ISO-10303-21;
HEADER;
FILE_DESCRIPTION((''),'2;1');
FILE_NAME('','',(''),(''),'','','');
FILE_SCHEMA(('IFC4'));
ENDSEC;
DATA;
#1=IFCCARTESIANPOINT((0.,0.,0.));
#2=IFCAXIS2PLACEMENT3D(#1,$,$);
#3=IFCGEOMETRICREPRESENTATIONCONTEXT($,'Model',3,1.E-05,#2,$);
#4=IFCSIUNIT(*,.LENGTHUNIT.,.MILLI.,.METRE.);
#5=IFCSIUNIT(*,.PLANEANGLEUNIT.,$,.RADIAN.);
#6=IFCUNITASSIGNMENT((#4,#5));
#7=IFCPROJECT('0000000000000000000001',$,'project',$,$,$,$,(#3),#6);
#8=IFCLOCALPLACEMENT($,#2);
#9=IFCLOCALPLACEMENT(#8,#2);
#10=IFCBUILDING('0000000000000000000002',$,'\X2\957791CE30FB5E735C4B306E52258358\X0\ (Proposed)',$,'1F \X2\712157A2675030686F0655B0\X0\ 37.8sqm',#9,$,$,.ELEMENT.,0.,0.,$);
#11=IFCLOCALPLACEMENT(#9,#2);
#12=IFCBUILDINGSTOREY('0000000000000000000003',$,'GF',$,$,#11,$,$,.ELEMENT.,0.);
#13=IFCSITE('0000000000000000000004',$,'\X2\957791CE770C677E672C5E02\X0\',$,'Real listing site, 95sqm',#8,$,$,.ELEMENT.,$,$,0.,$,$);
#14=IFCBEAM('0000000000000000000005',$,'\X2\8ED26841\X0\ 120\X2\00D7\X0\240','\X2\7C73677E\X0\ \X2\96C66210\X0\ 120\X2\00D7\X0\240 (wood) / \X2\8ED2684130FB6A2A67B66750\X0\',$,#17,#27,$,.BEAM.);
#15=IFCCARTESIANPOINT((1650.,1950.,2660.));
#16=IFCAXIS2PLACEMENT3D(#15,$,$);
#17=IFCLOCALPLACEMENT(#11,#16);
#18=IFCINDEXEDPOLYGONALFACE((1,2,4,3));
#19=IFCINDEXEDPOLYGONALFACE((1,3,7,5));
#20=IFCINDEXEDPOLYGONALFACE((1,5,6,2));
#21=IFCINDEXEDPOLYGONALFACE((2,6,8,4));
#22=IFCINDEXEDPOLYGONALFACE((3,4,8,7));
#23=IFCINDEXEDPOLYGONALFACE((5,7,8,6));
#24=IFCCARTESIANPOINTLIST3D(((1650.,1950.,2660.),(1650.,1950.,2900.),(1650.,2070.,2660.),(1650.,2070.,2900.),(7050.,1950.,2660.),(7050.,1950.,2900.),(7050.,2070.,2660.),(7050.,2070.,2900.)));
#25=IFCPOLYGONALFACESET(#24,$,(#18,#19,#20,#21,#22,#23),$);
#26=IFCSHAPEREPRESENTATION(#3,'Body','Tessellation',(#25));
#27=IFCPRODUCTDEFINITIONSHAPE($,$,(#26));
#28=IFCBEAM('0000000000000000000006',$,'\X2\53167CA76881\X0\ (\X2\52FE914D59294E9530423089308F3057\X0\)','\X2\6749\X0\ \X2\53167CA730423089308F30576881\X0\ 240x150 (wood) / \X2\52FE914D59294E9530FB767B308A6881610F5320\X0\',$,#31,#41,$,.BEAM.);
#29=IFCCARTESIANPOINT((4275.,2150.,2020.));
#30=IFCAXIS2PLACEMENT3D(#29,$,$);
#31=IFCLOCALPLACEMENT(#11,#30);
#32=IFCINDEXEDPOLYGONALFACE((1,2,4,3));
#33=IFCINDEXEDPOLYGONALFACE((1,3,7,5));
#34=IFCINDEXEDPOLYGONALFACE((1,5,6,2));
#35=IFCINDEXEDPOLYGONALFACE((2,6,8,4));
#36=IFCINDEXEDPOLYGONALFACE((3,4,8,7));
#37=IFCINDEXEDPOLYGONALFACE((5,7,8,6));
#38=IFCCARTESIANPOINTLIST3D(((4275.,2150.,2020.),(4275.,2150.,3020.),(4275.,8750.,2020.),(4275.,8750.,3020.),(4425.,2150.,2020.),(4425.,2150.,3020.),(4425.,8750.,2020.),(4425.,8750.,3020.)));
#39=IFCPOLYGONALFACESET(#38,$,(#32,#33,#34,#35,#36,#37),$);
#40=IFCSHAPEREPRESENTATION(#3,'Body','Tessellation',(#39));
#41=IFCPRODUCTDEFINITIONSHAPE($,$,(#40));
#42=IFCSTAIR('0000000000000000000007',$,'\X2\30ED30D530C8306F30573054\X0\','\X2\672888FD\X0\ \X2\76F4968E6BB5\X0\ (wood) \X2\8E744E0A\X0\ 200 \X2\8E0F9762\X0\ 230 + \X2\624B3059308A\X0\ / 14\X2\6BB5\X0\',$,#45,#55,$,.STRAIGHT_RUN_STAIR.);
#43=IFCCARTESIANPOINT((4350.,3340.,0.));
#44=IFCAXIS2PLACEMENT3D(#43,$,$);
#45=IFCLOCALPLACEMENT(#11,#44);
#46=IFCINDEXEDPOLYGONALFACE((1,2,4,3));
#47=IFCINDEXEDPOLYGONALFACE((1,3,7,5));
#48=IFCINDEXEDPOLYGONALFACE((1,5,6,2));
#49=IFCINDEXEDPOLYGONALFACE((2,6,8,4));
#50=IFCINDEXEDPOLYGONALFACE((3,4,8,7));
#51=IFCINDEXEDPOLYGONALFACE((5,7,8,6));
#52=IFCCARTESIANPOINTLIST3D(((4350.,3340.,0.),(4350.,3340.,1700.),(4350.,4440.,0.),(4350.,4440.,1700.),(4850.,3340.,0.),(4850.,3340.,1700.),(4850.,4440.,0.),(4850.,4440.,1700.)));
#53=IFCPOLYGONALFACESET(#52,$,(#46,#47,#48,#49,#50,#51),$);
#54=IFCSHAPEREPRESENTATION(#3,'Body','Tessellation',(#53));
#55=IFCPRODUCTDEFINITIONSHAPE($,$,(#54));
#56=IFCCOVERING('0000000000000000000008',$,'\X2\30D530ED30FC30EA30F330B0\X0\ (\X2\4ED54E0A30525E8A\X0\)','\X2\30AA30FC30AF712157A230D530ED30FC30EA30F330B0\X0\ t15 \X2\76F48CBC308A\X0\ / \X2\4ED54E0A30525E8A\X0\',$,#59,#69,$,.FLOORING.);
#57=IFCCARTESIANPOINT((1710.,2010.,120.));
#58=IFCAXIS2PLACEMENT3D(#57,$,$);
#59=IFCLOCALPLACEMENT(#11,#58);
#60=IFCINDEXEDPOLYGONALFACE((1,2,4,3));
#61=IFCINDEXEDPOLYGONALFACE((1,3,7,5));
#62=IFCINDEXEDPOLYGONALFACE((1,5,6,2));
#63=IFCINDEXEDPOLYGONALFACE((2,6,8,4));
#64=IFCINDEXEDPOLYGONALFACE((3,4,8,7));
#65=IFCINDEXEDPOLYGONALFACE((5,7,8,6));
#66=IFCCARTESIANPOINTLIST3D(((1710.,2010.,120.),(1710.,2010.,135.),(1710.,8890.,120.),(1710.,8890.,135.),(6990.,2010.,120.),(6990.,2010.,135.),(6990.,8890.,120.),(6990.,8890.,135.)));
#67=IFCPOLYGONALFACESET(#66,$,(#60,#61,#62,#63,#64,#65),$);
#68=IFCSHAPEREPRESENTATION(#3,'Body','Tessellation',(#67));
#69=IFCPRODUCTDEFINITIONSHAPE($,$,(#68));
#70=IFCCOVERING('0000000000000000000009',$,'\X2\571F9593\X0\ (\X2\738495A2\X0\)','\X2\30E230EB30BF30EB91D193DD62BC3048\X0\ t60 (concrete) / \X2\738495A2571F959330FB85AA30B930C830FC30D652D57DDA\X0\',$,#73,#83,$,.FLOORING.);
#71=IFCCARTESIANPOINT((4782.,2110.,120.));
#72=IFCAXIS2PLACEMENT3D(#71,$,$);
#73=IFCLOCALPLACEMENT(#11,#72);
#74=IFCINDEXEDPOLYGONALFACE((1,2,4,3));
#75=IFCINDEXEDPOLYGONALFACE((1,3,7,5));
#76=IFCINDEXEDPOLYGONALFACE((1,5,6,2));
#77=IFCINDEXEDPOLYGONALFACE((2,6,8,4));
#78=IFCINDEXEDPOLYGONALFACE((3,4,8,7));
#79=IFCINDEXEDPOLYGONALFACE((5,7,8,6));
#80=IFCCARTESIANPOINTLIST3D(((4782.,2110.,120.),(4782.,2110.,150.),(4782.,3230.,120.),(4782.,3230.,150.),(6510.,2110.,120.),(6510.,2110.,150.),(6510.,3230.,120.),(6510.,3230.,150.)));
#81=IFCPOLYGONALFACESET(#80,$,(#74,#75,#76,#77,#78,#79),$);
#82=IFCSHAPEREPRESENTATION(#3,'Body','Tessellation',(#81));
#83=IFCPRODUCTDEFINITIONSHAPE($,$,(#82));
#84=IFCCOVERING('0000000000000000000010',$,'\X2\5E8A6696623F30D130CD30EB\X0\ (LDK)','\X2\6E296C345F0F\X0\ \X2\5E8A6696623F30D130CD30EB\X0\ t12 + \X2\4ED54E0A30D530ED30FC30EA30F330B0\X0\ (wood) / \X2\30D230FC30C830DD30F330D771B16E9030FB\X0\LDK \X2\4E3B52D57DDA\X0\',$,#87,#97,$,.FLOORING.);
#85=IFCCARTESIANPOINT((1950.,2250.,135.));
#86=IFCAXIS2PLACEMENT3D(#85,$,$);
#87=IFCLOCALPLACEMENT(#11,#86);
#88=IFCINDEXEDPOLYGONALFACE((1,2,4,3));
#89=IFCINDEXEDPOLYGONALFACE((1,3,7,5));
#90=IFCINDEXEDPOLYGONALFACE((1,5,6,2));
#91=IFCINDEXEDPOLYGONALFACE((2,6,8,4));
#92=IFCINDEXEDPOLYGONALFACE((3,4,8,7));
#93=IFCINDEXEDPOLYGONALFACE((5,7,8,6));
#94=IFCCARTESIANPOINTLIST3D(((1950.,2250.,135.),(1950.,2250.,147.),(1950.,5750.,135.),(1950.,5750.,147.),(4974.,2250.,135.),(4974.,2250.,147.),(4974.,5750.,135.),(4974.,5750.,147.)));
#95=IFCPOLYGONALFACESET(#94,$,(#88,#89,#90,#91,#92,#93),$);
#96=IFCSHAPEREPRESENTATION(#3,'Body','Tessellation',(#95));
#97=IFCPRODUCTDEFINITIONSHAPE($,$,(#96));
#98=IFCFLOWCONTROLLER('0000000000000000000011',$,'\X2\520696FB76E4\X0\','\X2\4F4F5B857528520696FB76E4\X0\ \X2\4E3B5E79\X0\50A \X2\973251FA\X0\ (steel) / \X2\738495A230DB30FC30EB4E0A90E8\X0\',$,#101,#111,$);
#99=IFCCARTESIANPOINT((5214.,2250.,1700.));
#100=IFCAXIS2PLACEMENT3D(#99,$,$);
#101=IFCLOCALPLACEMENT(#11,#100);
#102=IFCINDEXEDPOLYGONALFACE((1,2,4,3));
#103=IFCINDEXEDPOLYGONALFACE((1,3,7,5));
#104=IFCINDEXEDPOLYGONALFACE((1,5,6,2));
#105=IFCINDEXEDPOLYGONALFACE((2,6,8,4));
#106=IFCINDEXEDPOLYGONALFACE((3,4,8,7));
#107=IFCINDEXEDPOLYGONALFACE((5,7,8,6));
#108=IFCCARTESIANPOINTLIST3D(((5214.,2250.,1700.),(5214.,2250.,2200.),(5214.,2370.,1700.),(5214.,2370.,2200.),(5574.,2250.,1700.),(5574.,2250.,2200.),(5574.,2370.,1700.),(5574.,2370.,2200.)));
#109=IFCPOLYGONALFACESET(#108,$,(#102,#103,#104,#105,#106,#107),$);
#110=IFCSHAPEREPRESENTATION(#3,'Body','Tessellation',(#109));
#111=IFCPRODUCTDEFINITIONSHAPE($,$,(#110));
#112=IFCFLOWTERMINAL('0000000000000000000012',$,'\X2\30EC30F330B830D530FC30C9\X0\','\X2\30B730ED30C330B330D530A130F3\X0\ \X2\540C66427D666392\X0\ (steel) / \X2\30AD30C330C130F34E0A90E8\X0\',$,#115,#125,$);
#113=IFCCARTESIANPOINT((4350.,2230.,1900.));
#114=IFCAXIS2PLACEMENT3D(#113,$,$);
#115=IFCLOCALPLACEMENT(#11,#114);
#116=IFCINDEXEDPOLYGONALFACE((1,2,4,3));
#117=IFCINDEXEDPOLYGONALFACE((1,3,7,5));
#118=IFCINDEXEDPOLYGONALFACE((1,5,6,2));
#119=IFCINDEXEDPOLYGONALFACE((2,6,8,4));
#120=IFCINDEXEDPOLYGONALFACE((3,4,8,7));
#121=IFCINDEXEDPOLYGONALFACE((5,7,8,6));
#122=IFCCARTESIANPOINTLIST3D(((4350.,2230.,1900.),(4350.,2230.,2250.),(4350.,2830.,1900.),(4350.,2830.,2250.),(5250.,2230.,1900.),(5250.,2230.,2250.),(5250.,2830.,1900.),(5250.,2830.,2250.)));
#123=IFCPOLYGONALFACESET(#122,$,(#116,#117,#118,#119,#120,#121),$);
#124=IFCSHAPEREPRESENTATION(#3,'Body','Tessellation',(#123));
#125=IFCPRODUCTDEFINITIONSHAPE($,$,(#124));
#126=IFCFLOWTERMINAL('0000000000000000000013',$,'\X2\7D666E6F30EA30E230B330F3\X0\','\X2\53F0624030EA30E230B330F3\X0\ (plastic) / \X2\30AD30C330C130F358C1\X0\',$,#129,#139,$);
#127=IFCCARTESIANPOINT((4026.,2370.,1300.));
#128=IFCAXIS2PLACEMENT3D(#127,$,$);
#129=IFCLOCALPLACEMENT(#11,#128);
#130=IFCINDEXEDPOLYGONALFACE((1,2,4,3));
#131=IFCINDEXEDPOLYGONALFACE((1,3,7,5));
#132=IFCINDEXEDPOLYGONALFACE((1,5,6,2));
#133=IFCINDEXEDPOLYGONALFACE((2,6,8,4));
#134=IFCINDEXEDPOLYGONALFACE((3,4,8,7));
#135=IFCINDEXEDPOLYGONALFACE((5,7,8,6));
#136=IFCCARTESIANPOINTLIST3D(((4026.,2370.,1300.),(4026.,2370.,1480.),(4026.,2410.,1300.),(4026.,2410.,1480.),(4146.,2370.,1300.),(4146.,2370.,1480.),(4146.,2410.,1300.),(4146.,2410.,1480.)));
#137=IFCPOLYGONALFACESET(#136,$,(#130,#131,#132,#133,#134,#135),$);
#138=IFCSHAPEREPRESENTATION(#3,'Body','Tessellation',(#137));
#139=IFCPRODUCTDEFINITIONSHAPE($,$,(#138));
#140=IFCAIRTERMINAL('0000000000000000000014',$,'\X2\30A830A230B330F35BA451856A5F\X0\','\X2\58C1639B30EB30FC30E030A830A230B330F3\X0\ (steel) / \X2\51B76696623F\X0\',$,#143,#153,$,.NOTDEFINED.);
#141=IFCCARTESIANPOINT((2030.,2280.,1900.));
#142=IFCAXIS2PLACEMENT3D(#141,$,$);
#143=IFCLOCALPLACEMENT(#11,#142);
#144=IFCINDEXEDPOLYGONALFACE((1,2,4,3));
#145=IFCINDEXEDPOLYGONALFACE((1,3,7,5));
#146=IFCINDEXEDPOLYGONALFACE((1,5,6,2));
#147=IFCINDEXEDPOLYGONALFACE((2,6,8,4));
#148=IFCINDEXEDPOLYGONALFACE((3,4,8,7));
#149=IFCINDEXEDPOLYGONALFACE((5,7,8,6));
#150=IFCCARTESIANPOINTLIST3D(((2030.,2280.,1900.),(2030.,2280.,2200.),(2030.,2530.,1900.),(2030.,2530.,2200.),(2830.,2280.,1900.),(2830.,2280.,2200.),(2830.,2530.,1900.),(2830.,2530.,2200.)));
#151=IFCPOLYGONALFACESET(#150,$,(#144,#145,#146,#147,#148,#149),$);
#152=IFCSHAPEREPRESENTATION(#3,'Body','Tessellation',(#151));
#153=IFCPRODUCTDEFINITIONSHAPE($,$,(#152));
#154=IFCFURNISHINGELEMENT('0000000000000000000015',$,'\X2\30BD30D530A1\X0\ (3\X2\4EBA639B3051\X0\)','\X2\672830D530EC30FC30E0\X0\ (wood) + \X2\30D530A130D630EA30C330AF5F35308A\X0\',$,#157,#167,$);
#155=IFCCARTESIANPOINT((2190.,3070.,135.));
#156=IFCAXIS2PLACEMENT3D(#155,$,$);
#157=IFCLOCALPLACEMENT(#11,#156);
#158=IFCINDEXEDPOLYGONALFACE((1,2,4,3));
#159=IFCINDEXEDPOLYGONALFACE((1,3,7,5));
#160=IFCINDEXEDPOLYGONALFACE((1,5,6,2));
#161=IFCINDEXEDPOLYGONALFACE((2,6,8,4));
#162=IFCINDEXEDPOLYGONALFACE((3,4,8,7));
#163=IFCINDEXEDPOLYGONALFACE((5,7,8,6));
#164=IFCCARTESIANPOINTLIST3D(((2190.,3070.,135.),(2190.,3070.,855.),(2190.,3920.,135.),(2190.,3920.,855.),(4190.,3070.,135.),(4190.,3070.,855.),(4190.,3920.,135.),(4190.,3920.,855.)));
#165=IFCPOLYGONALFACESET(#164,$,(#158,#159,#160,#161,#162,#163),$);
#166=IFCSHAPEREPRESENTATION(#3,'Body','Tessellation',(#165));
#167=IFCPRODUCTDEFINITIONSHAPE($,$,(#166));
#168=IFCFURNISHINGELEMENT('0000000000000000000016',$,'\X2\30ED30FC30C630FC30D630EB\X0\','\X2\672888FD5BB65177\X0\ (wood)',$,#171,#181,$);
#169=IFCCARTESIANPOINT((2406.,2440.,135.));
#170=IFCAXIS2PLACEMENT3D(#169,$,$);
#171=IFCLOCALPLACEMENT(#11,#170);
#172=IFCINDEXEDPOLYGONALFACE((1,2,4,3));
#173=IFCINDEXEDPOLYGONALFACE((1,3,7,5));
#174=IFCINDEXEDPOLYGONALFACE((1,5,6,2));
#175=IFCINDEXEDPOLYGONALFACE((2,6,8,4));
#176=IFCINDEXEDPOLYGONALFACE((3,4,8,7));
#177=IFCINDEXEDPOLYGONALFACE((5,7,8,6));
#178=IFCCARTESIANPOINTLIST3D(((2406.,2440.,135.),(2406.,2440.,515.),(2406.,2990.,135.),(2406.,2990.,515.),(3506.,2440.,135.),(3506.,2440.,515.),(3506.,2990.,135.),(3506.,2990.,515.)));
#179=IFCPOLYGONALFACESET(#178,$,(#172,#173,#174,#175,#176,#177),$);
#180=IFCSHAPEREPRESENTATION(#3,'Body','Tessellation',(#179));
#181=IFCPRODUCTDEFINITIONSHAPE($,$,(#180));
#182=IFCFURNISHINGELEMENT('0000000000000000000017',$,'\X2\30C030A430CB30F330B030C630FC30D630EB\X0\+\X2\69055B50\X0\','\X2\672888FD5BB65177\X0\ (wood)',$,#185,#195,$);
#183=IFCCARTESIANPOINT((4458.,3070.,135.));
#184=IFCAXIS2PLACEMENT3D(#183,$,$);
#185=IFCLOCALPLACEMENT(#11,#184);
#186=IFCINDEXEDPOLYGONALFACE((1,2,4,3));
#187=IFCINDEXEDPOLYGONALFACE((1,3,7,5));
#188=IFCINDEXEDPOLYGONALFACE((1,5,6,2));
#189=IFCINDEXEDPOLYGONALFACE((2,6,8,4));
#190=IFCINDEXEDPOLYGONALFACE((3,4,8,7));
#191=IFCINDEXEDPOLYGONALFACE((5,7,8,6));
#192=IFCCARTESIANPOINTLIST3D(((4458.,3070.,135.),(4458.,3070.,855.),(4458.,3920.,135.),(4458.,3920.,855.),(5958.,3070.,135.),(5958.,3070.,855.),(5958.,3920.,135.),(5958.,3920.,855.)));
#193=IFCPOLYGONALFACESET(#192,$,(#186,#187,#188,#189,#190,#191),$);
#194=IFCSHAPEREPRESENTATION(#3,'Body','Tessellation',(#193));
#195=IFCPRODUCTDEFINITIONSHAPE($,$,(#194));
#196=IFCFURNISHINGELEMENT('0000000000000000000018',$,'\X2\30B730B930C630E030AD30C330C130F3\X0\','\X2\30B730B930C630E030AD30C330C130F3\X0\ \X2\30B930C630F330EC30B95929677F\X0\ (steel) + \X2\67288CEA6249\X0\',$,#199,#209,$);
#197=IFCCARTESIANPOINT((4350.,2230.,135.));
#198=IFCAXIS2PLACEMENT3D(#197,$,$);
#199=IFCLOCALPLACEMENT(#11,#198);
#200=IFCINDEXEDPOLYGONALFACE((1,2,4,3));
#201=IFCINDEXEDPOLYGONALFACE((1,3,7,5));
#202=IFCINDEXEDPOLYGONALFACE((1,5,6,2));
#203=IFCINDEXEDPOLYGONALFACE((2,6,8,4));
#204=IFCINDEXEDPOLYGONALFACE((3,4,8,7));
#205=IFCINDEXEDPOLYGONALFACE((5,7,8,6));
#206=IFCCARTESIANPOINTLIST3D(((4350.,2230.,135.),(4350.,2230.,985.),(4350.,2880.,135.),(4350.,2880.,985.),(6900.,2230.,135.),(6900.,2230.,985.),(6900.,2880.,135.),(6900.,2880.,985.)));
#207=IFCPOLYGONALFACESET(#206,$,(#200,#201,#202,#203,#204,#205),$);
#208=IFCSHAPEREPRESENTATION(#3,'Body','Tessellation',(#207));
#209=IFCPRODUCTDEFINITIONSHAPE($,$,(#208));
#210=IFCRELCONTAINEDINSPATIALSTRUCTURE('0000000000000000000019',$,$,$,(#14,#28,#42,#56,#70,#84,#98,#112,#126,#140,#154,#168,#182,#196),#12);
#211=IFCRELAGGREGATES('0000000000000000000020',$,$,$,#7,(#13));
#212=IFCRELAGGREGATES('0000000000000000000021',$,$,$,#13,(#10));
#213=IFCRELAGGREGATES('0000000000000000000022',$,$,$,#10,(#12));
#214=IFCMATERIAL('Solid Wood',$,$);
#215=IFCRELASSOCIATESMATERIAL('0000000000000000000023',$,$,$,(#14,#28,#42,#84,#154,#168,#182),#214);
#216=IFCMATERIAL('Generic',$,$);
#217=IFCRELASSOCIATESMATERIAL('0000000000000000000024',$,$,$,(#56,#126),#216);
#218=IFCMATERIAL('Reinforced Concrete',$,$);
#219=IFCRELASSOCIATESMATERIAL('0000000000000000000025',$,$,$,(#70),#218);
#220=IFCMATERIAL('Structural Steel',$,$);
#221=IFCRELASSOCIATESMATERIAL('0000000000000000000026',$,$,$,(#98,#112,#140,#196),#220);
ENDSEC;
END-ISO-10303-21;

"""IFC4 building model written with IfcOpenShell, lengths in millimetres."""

from ifc_helpers import new_model, si_unit, frame, frame_2d, origin, place, context, project, spatial, rectangle, extrude, material, element, save


model = new_model("IFC4")

# Units and contexts
model_context = context("Model", 3, precision=1e-05, world=origin())
ifc_project = project(units=[si_unit("LENGTHUNIT", "METRE", prefix="MILLI"), si_unit("PLANEANGLEUNIT", "RADIAN")], contexts=[model_context])

# Site, building, storey
site_placement = place(None, origin())
site = spatial("IfcSite", under=ifc_project, at=site_placement, Name="長野県松本市", ObjectType="Real listing site, 95sqm", CompositionType="ELEMENT", RefElevation=0.0)
building_placement = place(site_placement, origin())
building = spatial("IfcBuilding", under=site, at=building_placement, Name="長野・平屋の別荘 (Proposed)", ObjectType="1F 無垢材と漆喰 37.8sqm", CompositionType="ELEMENT", ElevationOfRefHeight=0.0, ElevationOfTerrain=0.0)
storey_placement = place(building_placement, origin())
storey = spatial("IfcBuildingStorey", under=building, at=storey_placement, Name="GF", CompositionType="ELEMENT", Elevation=0.0)

# Beams
ifc_material_1 = material(Name="Solid Wood")
beam_1_placement = place(storey_placement, frame((1650.0, 1950.0, 2660.0)))
element("IfcBeam", 1, at=beam_1_placement, inside=storey, material=ifc_material_1, Name="軒桁 120×240", Description="米松 集成 120×240 (wood) / 軒桁・横架材", PredefinedType="BEAM", context=model_context, shape_type="SweptSolid", body=[
    extrude(rectangle(XDim=5400.0, YDim=120.0, at=frame_2d((2700.0, 60.0))), frame((1650.0, 1950.0, 2660.0)), (0.0, 0.0, 1.0), 240.0),
])
beam_2_placement = place(storey_placement, frame((4275.0, 2150.0, 2020.0)))
element("IfcBeam", 2, at=beam_2_placement, inside=storey, material=ifc_material_1, Name="化粧梁 (勾配天井あらわし)", Description="杉 化粧あらわし梁 240x150 (wood) / 勾配天井・登り梁意匠", PredefinedType="BEAM", context=model_context, shape_type="SweptSolid", body=[
    extrude(rectangle(XDim=150.0, YDim=6600.0, at=frame_2d((75.0, 3300.0))), frame((4275.0, 2150.0, 2020.0)), (0.0, 0.0, 1.0), 1000.0),
])

# Stair
stair_placement = place(storey_placement, frame((4350.0, 3340.0, 0.0)))
element("IfcStair", 3, at=stair_placement, inside=storey, material=ifc_material_1, Name="ロフトはしご", Description="木製 直階段 (wood) 蹴上 200 踏面 230 + 手すり / 14段", PredefinedType="STRAIGHT_RUN_STAIR", context=model_context, shape_type="SweptSolid", body=[
    extrude(rectangle(XDim=500.0, YDim=1100.0, at=frame_2d((250.0, 550.0))), frame((4350.0, 3340.0, 0.0)), (0.0, 0.0, 1.0), 1700.0),
])

# Coverings
ifc_material_2 = material(Name="Generic")
covering_1_placement = place(storey_placement, frame((1710.0, 2010.0, 120.0)))
element("IfcCovering", 4, at=covering_1_placement, inside=storey, material=ifc_material_2, Name="フローリング (仕上げ床)", Description="オーク無垢フローリング t15 直貼り / 仕上げ床", PredefinedType="FLOORING", context=model_context, shape_type="SweptSolid", body=[
    extrude(rectangle(XDim=5280.0, YDim=6880.0, at=frame_2d((2640.0, 3440.0))), frame((1710.0, 2010.0, 120.0)), (0.0, 0.0, 1.0), 15.0),
])
ifc_material_3 = material(Name="Reinforced Concrete")
covering_2_placement = place(storey_placement, frame((4782.0, 2110.0, 120.0)))
element("IfcCovering", 5, at=covering_2_placement, inside=storey, material=ifc_material_3, Name="土間 (玄関)", Description="モルタル金鏝押え t60 (concrete) / 玄関土間・薪ストーブ動線", PredefinedType="FLOORING", context=model_context, shape_type="SweptSolid", body=[
    extrude(rectangle(XDim=1728.0, YDim=1120.0, at=frame_2d((864.0, 560.0))), frame((4782.0, 2110.0, 120.0)), (0.0, 0.0, 1.0), 30.0),
])
covering_3_placement = place(storey_placement, frame((1950.0, 2250.0, 135.0)))
element("IfcCovering", 6, at=covering_3_placement, inside=storey, material=ifc_material_1, Name="床暖房パネル (LDK)", Description="温水式 床暖房パネル t12 + 仕上フローリング (wood) / ヒートポンプ熱源・LDK 主動線", PredefinedType="FLOORING", context=model_context, shape_type="SweptSolid", body=[
    extrude(rectangle(XDim=3024.0, YDim=3500.0, at=frame_2d((1512.0, 1750.0))), frame((1950.0, 2250.0, 135.0)), (0.0, 0.0, 1.0), 12.0),
])

# Flow controller
ifc_material_4 = material(Name="Structural Steel")
flow_controller_placement = place(storey_placement, frame((5214.0, 2250.0, 1700.0)))
element("IfcFlowController", 7, at=flow_controller_placement, inside=storey, material=ifc_material_4, Name="分電盤", Description="住宅用分電盤 主幹50A 露出 (steel) / 玄関ホール上部", context=model_context, shape_type="SweptSolid", body=[
    extrude(rectangle(XDim=360.0, YDim=120.0, at=frame_2d((180.0, 60.0))), frame((5214.0, 2250.0, 1700.0)), (0.0, 0.0, 1.0), 500.0),
])

# Flow terminals
flow_terminal_1_placement = place(storey_placement, frame((4350.0, 2230.0, 1900.0)))
element("IfcFlowTerminal", 8, at=flow_terminal_1_placement, inside=storey, material=ifc_material_4, Name="レンジフード", Description="シロッコファン 同時給排 (steel) / キッチン上部", context=model_context, shape_type="SweptSolid", body=[
    extrude(rectangle(XDim=900.0, YDim=600.0, at=frame_2d((450.0, 300.0))), frame((4350.0, 2230.0, 1900.0)), (0.0, 0.0, 1.0), 350.0),
])
flow_terminal_2_placement = place(storey_placement, frame((4026.0, 2370.0, 1300.0)))
element("IfcFlowTerminal", 9, at=flow_terminal_2_placement, inside=storey, material=ifc_material_2, Name="給湯リモコン", Description="台所リモコン (plastic) / キッチン壁", context=model_context, shape_type="SweptSolid", body=[
    extrude(rectangle(XDim=120.0, YDim=40.0, at=frame_2d((60.0, 20.0))), frame((4026.0, 2370.0, 1300.0)), (0.0, 0.0, 1.0), 180.0),
])

# Air terminal
air_terminal_placement = place(storey_placement, frame((2030.0, 2280.0, 1900.0)))
element("IfcAirTerminal", 10, at=air_terminal_placement, inside=storey, material=ifc_material_4, Name="エアコン室内機", Description="壁掛ルームエアコン (steel) / 冷暖房", PredefinedType="NOTDEFINED", context=model_context, shape_type="SweptSolid", body=[
    extrude(rectangle(XDim=800.0, YDim=250.0, at=frame_2d((400.0, 125.0))), frame((2030.0, 2280.0, 1900.0)), (0.0, 0.0, 1.0), 300.0),
])

# Furnishing elements
furnishing_1_placement = place(storey_placement, frame((2190.0, 3070.0, 135.0)))
element("IfcFurnishingElement", 11, at=furnishing_1_placement, inside=storey, material=ifc_material_1, Name="ソファ (3人掛け)", Description="木フレーム (wood) + ファブリック張り", context=model_context, shape_type="SweptSolid", body=[
    extrude(rectangle(XDim=2000.0, YDim=850.0, at=frame_2d((1000.0, 425.0))), frame((2190.0, 3070.0, 135.0)), (0.0, 0.0, 1.0), 720.0),
])
furnishing_2_placement = place(storey_placement, frame((2406.0, 2440.0, 135.0)))
element("IfcFurnishingElement", 12, at=furnishing_2_placement, inside=storey, material=ifc_material_1, Name="ローテーブル", Description="木製家具 (wood)", context=model_context, shape_type="SweptSolid", body=[
    extrude(rectangle(XDim=1100.0, YDim=550.0, at=frame_2d((550.0, 275.0))), frame((2406.0, 2440.0, 135.0)), (0.0, 0.0, 1.0), 380.0),
])
furnishing_3_placement = place(storey_placement, frame((4458.0, 3070.0, 135.0)))
element("IfcFurnishingElement", 13, at=furnishing_3_placement, inside=storey, material=ifc_material_1, Name="ダイニングテーブル+椅子", Description="木製家具 (wood)", context=model_context, shape_type="SweptSolid", body=[
    extrude(rectangle(XDim=1500.0, YDim=850.0, at=frame_2d((750.0, 425.0))), frame((4458.0, 3070.0, 135.0)), (0.0, 0.0, 1.0), 720.0),
])
furnishing_4_placement = place(storey_placement, frame((4350.0, 2230.0, 135.0)))
element("IfcFurnishingElement", 14, at=furnishing_4_placement, inside=storey, material=ifc_material_4, Name="システムキッチン", Description="システムキッチン ステンレス天板 (steel) + 木質扉", context=model_context, shape_type="SweptSolid", body=[
    extrude(rectangle(XDim=2550.0, YDim=650.0, at=frame_2d((1275.0, 325.0))), frame((4350.0, 2230.0, 135.0)), (0.0, 0.0, 1.0), 850.0),
])

save(model, "model.ifc")
